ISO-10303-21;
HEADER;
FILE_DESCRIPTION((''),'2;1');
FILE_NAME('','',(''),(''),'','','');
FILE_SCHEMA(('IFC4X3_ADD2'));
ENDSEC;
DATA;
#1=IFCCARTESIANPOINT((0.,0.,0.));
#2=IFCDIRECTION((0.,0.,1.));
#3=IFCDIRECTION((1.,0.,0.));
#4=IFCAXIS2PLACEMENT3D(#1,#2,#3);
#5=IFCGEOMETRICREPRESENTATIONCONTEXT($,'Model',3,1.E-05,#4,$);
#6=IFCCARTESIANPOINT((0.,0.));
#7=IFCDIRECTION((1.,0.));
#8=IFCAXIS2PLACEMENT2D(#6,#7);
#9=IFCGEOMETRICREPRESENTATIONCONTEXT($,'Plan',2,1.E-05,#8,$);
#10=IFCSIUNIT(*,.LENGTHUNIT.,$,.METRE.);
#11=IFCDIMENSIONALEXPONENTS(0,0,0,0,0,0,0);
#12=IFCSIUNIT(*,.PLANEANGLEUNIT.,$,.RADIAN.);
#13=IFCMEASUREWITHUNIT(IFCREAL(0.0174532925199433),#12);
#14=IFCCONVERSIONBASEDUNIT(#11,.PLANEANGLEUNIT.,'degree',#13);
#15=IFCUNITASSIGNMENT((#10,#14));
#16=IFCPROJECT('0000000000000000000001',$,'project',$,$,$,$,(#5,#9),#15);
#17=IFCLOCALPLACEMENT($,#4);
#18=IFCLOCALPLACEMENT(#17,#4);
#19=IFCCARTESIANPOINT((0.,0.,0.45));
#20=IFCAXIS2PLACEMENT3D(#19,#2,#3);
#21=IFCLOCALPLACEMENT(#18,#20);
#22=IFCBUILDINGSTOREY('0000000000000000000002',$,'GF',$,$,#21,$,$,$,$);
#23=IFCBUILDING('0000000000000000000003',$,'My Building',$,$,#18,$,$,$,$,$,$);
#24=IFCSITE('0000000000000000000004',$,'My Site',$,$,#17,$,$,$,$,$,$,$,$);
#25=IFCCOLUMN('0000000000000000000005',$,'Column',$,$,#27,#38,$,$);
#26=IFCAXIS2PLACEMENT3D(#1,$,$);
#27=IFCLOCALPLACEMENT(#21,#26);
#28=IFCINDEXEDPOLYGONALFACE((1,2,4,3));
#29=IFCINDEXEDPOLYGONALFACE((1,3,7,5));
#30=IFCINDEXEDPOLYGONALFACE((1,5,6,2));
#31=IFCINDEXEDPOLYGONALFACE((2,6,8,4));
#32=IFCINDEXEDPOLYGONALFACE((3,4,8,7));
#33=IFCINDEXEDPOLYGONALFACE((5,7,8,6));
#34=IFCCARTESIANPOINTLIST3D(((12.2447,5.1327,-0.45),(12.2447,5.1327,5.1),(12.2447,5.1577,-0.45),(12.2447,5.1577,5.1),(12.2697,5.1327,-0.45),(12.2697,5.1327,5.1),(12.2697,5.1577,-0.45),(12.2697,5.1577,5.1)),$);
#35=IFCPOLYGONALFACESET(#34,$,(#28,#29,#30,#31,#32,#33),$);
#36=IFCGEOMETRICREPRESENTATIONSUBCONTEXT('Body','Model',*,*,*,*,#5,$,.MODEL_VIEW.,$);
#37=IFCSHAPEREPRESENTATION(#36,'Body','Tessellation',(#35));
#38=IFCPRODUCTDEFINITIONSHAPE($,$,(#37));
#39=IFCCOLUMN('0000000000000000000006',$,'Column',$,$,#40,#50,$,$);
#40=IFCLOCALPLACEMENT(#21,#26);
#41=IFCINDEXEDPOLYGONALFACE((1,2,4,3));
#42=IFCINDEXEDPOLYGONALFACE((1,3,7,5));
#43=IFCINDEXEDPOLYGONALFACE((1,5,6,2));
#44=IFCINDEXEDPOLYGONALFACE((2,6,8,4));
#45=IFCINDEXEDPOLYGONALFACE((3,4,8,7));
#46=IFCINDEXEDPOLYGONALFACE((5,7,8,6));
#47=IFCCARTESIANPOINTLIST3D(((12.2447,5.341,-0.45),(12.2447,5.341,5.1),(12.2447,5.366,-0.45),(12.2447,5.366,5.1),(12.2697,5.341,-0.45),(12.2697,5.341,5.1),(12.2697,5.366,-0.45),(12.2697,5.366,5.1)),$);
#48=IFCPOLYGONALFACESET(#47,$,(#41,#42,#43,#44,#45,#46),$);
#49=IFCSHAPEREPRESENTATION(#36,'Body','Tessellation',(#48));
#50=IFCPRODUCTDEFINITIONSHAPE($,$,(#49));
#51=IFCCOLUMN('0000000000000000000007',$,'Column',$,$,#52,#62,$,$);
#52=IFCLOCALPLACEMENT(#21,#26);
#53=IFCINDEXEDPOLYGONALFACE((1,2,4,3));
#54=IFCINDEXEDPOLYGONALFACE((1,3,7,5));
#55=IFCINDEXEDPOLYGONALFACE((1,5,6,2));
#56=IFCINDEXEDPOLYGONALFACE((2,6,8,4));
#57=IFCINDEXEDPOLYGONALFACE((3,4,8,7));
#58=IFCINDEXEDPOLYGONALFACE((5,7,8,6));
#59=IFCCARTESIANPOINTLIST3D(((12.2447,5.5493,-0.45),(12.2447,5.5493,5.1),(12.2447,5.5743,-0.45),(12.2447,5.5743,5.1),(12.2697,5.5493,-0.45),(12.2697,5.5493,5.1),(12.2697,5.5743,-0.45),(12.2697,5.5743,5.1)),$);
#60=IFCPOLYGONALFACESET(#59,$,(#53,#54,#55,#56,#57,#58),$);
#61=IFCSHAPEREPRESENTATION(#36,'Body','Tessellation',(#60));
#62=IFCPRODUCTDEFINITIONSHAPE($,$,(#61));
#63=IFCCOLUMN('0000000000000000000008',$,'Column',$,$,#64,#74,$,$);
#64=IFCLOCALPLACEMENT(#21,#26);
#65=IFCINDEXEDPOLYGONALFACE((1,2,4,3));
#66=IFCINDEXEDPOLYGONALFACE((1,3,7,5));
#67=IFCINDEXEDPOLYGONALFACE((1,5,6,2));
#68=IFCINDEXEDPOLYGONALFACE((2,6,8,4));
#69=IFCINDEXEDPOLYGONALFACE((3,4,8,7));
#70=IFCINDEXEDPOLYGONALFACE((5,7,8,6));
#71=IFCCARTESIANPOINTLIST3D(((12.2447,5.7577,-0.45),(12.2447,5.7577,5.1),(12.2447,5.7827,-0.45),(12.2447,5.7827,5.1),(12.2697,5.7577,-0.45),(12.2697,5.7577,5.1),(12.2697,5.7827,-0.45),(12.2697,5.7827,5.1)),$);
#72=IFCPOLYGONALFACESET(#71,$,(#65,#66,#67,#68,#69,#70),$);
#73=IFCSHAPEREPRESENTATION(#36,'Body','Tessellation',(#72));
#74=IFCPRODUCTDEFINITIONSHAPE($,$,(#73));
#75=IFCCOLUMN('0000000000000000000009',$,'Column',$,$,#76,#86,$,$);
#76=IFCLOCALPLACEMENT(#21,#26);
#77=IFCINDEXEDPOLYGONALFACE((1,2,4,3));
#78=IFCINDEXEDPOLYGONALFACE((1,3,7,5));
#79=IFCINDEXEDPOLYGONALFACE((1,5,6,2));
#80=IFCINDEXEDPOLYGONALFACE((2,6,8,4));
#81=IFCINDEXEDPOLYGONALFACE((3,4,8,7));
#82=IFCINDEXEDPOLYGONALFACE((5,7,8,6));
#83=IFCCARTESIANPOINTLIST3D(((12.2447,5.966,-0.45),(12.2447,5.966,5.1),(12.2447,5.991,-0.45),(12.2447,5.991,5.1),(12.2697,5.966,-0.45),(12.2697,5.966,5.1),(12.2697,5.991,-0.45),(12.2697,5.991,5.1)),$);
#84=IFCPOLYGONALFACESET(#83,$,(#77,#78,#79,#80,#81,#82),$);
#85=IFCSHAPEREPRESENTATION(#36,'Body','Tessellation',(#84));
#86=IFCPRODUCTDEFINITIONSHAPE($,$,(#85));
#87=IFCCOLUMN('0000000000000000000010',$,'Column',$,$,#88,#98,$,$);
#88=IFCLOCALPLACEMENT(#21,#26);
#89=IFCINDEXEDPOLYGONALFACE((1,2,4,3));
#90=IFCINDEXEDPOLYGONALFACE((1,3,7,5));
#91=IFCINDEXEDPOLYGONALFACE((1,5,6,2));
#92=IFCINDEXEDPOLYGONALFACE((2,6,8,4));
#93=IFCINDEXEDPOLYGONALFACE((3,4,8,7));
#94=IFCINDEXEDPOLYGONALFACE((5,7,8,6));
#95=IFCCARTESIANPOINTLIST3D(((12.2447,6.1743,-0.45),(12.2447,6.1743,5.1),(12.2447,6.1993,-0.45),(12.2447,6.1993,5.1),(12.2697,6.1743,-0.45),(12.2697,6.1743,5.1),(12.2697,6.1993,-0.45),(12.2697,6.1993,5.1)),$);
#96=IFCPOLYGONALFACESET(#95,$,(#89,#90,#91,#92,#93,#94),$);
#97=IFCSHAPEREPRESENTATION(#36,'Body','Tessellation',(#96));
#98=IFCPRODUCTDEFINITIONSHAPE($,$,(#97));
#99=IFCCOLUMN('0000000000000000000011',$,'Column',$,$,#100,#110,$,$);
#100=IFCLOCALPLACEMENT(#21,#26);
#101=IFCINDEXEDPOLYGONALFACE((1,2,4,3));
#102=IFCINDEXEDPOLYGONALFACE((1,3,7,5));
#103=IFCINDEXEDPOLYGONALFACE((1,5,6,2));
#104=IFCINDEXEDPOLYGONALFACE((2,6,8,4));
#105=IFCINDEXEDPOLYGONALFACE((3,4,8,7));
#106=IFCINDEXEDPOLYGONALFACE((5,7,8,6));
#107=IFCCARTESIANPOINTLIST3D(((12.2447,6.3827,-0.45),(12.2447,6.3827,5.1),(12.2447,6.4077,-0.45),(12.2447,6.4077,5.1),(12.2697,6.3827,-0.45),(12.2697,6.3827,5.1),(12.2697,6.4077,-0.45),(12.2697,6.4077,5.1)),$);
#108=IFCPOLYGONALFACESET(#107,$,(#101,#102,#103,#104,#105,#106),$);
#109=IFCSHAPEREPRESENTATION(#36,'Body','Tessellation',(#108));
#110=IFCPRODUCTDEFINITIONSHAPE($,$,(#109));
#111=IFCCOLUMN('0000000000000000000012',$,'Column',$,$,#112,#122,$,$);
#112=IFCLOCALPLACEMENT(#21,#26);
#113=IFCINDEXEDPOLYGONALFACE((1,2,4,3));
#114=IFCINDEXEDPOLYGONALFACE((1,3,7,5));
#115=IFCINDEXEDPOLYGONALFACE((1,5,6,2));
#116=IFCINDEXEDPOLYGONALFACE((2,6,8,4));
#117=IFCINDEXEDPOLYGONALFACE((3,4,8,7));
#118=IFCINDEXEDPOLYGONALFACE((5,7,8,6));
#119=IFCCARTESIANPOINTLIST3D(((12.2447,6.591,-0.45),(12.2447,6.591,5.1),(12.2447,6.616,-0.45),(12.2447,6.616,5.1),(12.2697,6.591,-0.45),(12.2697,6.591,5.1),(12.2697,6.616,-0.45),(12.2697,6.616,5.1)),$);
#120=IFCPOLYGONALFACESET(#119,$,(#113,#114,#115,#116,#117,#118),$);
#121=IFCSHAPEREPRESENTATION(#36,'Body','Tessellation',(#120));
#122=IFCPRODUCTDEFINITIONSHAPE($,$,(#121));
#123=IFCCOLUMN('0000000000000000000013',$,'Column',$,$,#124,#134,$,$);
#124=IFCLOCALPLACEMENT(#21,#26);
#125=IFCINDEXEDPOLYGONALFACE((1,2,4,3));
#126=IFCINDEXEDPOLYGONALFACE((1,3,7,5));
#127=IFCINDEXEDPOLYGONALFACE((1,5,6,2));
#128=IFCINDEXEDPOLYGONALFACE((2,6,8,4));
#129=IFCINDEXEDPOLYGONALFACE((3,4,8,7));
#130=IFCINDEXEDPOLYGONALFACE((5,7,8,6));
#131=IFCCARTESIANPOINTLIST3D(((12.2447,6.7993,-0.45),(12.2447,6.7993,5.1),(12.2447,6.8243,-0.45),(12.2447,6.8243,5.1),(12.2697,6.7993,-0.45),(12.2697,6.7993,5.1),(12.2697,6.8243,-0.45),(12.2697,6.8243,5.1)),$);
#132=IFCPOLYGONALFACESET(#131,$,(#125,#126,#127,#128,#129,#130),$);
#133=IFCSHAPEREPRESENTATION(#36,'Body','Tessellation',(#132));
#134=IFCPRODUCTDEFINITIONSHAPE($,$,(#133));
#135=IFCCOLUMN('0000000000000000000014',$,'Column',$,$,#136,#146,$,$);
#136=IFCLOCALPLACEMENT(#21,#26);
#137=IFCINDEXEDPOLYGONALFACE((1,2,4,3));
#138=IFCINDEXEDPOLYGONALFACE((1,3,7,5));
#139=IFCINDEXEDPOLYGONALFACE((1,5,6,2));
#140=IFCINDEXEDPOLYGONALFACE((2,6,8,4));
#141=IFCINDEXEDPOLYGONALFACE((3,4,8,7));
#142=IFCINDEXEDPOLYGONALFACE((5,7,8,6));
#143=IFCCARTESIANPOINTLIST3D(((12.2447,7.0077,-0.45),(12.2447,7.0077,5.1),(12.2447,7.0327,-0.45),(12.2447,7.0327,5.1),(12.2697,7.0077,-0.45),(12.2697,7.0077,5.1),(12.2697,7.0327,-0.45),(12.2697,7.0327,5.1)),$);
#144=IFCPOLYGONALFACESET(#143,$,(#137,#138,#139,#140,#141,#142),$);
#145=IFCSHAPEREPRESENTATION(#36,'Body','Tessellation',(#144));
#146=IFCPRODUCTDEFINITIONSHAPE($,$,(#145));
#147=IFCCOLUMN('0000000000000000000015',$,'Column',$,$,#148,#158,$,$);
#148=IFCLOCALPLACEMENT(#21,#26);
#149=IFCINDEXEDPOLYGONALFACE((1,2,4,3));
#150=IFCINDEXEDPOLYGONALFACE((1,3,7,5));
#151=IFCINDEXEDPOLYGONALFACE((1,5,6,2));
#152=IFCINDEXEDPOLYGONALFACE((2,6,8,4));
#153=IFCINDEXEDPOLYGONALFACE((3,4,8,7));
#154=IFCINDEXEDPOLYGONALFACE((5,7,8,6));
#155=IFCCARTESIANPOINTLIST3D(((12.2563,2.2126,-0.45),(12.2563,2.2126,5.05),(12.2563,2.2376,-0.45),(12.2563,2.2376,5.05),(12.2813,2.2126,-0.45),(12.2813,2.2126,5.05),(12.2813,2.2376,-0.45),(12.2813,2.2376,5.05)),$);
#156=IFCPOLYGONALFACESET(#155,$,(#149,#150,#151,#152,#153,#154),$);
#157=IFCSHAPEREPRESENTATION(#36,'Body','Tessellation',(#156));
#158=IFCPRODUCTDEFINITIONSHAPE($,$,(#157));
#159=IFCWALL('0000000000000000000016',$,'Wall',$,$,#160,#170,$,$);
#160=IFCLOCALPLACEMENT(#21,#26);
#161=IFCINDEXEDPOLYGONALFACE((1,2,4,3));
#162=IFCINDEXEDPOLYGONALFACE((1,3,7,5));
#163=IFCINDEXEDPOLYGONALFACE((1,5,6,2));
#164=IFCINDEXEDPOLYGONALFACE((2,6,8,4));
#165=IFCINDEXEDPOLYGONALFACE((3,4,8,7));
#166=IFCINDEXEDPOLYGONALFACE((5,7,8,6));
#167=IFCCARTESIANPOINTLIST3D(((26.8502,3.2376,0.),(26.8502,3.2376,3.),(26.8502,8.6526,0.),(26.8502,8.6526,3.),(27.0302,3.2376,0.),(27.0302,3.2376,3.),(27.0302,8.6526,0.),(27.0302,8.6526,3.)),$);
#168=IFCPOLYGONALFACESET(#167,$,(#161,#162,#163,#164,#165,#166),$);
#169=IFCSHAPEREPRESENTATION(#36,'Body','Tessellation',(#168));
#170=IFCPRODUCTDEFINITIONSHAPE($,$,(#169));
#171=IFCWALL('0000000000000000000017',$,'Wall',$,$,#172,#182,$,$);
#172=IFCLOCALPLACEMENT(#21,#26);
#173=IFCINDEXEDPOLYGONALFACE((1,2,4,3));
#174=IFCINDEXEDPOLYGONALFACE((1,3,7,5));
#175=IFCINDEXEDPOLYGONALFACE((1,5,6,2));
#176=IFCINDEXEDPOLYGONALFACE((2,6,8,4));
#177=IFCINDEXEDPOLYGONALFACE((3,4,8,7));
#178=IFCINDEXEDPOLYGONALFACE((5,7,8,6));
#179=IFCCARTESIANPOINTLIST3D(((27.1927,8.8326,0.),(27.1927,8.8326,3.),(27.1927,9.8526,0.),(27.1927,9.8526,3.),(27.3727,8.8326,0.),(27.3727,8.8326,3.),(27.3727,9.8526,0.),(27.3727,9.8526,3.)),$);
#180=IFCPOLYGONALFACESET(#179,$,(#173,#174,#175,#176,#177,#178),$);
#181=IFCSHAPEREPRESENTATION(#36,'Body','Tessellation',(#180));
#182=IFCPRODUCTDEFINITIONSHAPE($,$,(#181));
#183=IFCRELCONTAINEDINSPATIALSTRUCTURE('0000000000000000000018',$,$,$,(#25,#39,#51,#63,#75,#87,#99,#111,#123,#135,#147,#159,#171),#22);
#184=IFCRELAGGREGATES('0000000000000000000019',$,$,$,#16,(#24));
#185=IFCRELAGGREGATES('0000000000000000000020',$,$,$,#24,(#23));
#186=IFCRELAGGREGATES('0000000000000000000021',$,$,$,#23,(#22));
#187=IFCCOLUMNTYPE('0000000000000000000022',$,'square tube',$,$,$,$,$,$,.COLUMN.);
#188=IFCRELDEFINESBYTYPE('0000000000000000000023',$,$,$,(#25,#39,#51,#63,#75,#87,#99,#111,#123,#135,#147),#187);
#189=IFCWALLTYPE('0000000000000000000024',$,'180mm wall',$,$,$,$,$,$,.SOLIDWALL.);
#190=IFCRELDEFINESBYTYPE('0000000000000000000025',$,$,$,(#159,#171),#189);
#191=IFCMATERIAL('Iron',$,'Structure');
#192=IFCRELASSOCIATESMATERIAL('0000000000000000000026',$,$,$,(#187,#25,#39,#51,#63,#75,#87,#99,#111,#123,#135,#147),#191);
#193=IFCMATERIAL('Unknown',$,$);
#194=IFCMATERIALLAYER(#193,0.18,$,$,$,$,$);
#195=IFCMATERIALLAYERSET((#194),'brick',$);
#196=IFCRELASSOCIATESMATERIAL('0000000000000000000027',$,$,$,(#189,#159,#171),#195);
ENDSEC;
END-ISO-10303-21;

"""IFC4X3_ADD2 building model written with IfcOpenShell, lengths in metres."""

from ifc_helpers import new_model, entity, si_unit, converted_unit, frame, origin_with_axes, origin_2d_with_axis, place, context, subcontext, project, spatial, indexed_curve, outline, extrude, material, layer, layer_set, layer_usage, material_profile, profile_set, profile_usage, type_object, element, save


model = new_model("IFC4X3_ADD2")

# Units and contexts
model_context = context("Model", 3, precision=1e-05, world=origin_with_axes())
plan_context = context("Plan", 2, precision=1e-05, world=origin_2d_with_axis())
body_context = subcontext(model_context, "Body", "Model", "MODEL_VIEW")
ifc_project = project(units=[si_unit("LENGTHUNIT", "METRE"), converted_unit("PLANEANGLEUNIT", "degree", entity("IfcReal", 0.0174532925199433), si_unit("PLANEANGLEUNIT", "RADIAN"), dimensions=[0, 0, 0, 0, 0, 0, 0])], contexts=[model_context, plan_context])

# Site, building, storey
site_placement = place(None, origin_with_axes())
site = spatial("IfcSite", under=ifc_project, at=site_placement, Name="My Site")
building_placement = place(site_placement, origin_with_axes())
building = spatial("IfcBuilding", under=site, at=building_placement, Name="My Building")
storey_placement = place(building_placement, frame((0.0, 0.0, 0.45), z_axis=(0.0, 0.0, 1.0), x_axis=(1.0, 0.0, 0.0)))
storey = spatial("IfcBuildingStorey", under=building, at=storey_placement, Name="GF")

# Columns
ifc_material_1 = material(Name="Iron", Category="Structure")
ifc_material_profile = material_profile(ifc_material_1, outline(indexed_curve([(-0.0125, -0.0125), (0.0125, -0.0125), (0.0125, 0.0125), (-0.0125, 0.0125), (-0.0125, -0.0125)])))
ifc_profile_set = profile_set([ifc_material_profile])
column_type = type_object("IfcColumnType", Name="square tube", PredefinedType="COLUMN", material=ifc_profile_set)
ifc_profile_usage_1 = profile_usage(ifc_profile_set, cardinal=5)
column_1_placement = place(storey_placement, frame((12.2572, 5.1452, -0.45), z_axis=(0.0, 0.0, 1.0), x_axis=(0.0, 1.0, 0.0)))
element("IfcColumn", 1, at=column_1_placement, inside=storey, type_object=column_type, material=ifc_profile_usage_1, Name="Column", context=body_context, shape_type="SweptSolid", body=[
    extrude(outline(indexed_curve([(-0.0125, -0.0125), (0.0125, -0.0125), (0.0125, 0.0125), (-0.0125, 0.0125), (-0.0125, -0.0125)])), origin_with_axes(), (0.0, 0.0, 1.0), 5.55),
])
ifc_profile_usage_2 = profile_usage(ifc_profile_set, cardinal=5)
column_2_placement = place(storey_placement, frame((12.2572, 5.3535, -0.45), z_axis=(0.0, 0.0, 1.0), x_axis=(0.0, 1.0, 0.0)))
element("IfcColumn", 2, at=column_2_placement, inside=storey, type_object=column_type, material=ifc_profile_usage_2, Name="Column", context=body_context, shape_type="SweptSolid", body=[
    extrude(outline(indexed_curve([(-0.0125, -0.0125), (0.0125, -0.0125), (0.0125, 0.0125), (-0.0125, 0.0125), (-0.0125, -0.0125)])), origin_with_axes(), (0.0, 0.0, 1.0), 5.55),
])
ifc_profile_usage_3 = profile_usage(ifc_profile_set, cardinal=5)
column_3_placement = place(storey_placement, frame((12.2572, 5.5618, -0.45), z_axis=(0.0, 0.0, 1.0), x_axis=(0.0, 1.0, 0.0)))
element("IfcColumn", 3, at=column_3_placement, inside=storey, type_object=column_type, material=ifc_profile_usage_3, Name="Column", context=body_context, shape_type="SweptSolid", body=[
    extrude(outline(indexed_curve([(-0.0125, -0.0125), (0.0125, -0.0125), (0.0125, 0.0125), (-0.0125, 0.0125), (-0.0125, -0.0125)])), origin_with_axes(), (0.0, 0.0, 1.0), 5.55),
])
ifc_profile_usage_4 = profile_usage(ifc_profile_set, cardinal=5)
column_4_placement = place(storey_placement, frame((12.2572, 5.7702, -0.45), z_axis=(0.0, 0.0, 1.0), x_axis=(0.0, 1.0, 0.0)))
element("IfcColumn", 4, at=column_4_placement, inside=storey, type_object=column_type, material=ifc_profile_usage_4, Name="Column", context=body_context, shape_type="SweptSolid", body=[
    extrude(outline(indexed_curve([(-0.0125, -0.0125), (0.0125, -0.0125), (0.0125, 0.0125), (-0.0125, 0.0125), (-0.0125, -0.0125)])), origin_with_axes(), (0.0, 0.0, 1.0), 5.55),
])
ifc_profile_usage_5 = profile_usage(ifc_profile_set, cardinal=5)
column_5_placement = place(storey_placement, frame((12.2572, 5.9785, -0.45), z_axis=(0.0, 0.0, 1.0), x_axis=(0.0, 1.0, 0.0)))
element("IfcColumn", 5, at=column_5_placement, inside=storey, type_object=column_type, material=ifc_profile_usage_5, Name="Column", context=body_context, shape_type="SweptSolid", body=[
    extrude(outline(indexed_curve([(-0.0125, -0.0125), (0.0125, -0.0125), (0.0125, 0.0125), (-0.0125, 0.0125), (-0.0125, -0.0125)])), origin_with_axes(), (0.0, 0.0, 1.0), 5.55),
])
ifc_profile_usage_6 = profile_usage(ifc_profile_set, cardinal=5)
column_6_placement = place(storey_placement, frame((12.2572, 6.1868, -0.45), z_axis=(0.0, 0.0, 1.0), x_axis=(0.0, 1.0, 0.0)))
element("IfcColumn", 6, at=column_6_placement, inside=storey, type_object=column_type, material=ifc_profile_usage_6, Name="Column", context=body_context, shape_type="SweptSolid", body=[
    extrude(outline(indexed_curve([(-0.0125, -0.0125), (0.0125, -0.0125), (0.0125, 0.0125), (-0.0125, 0.0125), (-0.0125, -0.0125)])), origin_with_axes(), (0.0, 0.0, 1.0), 5.55),
])
ifc_profile_usage_7 = profile_usage(ifc_profile_set, cardinal=5)
column_7_placement = place(storey_placement, frame((12.2572, 6.3952, -0.45), z_axis=(0.0, 0.0, 1.0), x_axis=(0.0, 1.0, 0.0)))
element("IfcColumn", 7, at=column_7_placement, inside=storey, type_object=column_type, material=ifc_profile_usage_7, Name="Column", context=body_context, shape_type="SweptSolid", body=[
    extrude(outline(indexed_curve([(-0.0125, -0.0125), (0.0125, -0.0125), (0.0125, 0.0125), (-0.0125, 0.0125), (-0.0125, -0.0125)])), origin_with_axes(), (0.0, 0.0, 1.0), 5.55),
])
ifc_profile_usage_8 = profile_usage(ifc_profile_set, cardinal=5)
column_8_placement = place(storey_placement, frame((12.2572, 6.6035, -0.45), z_axis=(0.0, 0.0, 1.0), x_axis=(0.0, 1.0, 0.0)))
element("IfcColumn", 8, at=column_8_placement, inside=storey, type_object=column_type, material=ifc_profile_usage_8, Name="Column", context=body_context, shape_type="SweptSolid", body=[
    extrude(outline(indexed_curve([(-0.0125, -0.0125), (0.0125, -0.0125), (0.0125, 0.0125), (-0.0125, 0.0125), (-0.0125, -0.0125)])), origin_with_axes(), (0.0, 0.0, 1.0), 5.55),
])
ifc_profile_usage_9 = profile_usage(ifc_profile_set, cardinal=5)
column_9_placement = place(storey_placement, frame((12.2572, 6.8118, -0.45), z_axis=(0.0, 0.0, 1.0), x_axis=(0.0, 1.0, 0.0)))
element("IfcColumn", 9, at=column_9_placement, inside=storey, type_object=column_type, material=ifc_profile_usage_9, Name="Column", context=body_context, shape_type="SweptSolid", body=[
    extrude(outline(indexed_curve([(-0.0125, -0.0125), (0.0125, -0.0125), (0.0125, 0.0125), (-0.0125, 0.0125), (-0.0125, -0.0125)])), origin_with_axes(), (0.0, 0.0, 1.0), 5.55),
])
ifc_profile_usage_10 = profile_usage(ifc_profile_set, cardinal=5)
column_10_placement = place(storey_placement, frame((12.2572, 7.0202, -0.45), z_axis=(0.0, 0.0, 1.0), x_axis=(0.0, 1.0, 0.0)))
element("IfcColumn", 10, at=column_10_placement, inside=storey, type_object=column_type, material=ifc_profile_usage_10, Name="Column", context=body_context, shape_type="SweptSolid", body=[
    extrude(outline(indexed_curve([(-0.0125, -0.0125), (0.0125, -0.0125), (0.0125, 0.0125), (-0.0125, 0.0125), (-0.0125, -0.0125)])), origin_with_axes(), (0.0, 0.0, 1.0), 5.55),
])
ifc_profile_usage_11 = profile_usage(ifc_profile_set, cardinal=5)
column_11_placement = place(storey_placement, frame((12.2688, 2.2251, -0.45), z_axis=(0.0, 0.0, 1.0), x_axis=(1.0, 0.0, 0.0)))
element("IfcColumn", 11, at=column_11_placement, inside=storey, type_object=column_type, material=ifc_profile_usage_11, Name="Column", context=body_context, shape_type="SweptSolid", body=[
    extrude(outline(indexed_curve([(-0.0125, -0.0125), (0.0125, -0.0125), (0.0125, 0.0125), (-0.0125, 0.0125), (-0.0125, -0.0125)])), origin_with_axes(), (0.0, 0.0, 1.0), 5.5),
])

# Walls
ifc_material_2 = material(Name="Unknown")
ifc_layer = layer(ifc_material_2, 0.18)
ifc_layer_set = layer_set([ifc_layer], Name="brick")
ifc_layer_usage_1 = layer_usage(ifc_layer_set, "AXIS2", "POSITIVE", 0.0)
wall_type = type_object("IfcWallType", Name="180mm wall", PredefinedType="SOLIDWALL", material=ifc_layer_set)
wall_1_placement = place(storey_placement, frame((27.0302, 3.2376, 0.0), z_axis=(0.0, 0.0, 1.0), x_axis=(0.0, 1.0, 0.0)))
element("IfcWall", 12, at=wall_1_placement, inside=storey, type_object=wall_type, material=ifc_layer_usage_1, Name="Wall", context=body_context, shape_type="SweptSolid", body=[
    extrude(outline(indexed_curve([(0.0, 0.0), (0.0, 0.18), (5.415, 0.18), (5.415, 0.0), (0.0, 0.0)], self_intersect=False)), origin_with_axes(), (0.0, 0.0, 1.0), 3.0),
])
ifc_layer_usage_2 = layer_usage(ifc_layer_set, "AXIS2", "POSITIVE", 0.0)
wall_2_placement = place(storey_placement, frame((27.3727, 8.8326, 0.0), z_axis=(0.0, 0.0, 1.0), x_axis=(0.0, 1.0, 0.0)))
element("IfcWall", 13, at=wall_2_placement, inside=storey, type_object=wall_type, material=ifc_layer_usage_2, Name="Wall", context=body_context, shape_type="SweptSolid", body=[
    extrude(outline(indexed_curve([(0.0, 0.0), (0.0, 0.18), (1.02, 0.18), (1.02, 0.0), (0.0, 0.0)], self_intersect=False)), origin_with_axes(), (0.0, 0.0, 1.0), 3.0),
])

save(model, "model.ifc")
